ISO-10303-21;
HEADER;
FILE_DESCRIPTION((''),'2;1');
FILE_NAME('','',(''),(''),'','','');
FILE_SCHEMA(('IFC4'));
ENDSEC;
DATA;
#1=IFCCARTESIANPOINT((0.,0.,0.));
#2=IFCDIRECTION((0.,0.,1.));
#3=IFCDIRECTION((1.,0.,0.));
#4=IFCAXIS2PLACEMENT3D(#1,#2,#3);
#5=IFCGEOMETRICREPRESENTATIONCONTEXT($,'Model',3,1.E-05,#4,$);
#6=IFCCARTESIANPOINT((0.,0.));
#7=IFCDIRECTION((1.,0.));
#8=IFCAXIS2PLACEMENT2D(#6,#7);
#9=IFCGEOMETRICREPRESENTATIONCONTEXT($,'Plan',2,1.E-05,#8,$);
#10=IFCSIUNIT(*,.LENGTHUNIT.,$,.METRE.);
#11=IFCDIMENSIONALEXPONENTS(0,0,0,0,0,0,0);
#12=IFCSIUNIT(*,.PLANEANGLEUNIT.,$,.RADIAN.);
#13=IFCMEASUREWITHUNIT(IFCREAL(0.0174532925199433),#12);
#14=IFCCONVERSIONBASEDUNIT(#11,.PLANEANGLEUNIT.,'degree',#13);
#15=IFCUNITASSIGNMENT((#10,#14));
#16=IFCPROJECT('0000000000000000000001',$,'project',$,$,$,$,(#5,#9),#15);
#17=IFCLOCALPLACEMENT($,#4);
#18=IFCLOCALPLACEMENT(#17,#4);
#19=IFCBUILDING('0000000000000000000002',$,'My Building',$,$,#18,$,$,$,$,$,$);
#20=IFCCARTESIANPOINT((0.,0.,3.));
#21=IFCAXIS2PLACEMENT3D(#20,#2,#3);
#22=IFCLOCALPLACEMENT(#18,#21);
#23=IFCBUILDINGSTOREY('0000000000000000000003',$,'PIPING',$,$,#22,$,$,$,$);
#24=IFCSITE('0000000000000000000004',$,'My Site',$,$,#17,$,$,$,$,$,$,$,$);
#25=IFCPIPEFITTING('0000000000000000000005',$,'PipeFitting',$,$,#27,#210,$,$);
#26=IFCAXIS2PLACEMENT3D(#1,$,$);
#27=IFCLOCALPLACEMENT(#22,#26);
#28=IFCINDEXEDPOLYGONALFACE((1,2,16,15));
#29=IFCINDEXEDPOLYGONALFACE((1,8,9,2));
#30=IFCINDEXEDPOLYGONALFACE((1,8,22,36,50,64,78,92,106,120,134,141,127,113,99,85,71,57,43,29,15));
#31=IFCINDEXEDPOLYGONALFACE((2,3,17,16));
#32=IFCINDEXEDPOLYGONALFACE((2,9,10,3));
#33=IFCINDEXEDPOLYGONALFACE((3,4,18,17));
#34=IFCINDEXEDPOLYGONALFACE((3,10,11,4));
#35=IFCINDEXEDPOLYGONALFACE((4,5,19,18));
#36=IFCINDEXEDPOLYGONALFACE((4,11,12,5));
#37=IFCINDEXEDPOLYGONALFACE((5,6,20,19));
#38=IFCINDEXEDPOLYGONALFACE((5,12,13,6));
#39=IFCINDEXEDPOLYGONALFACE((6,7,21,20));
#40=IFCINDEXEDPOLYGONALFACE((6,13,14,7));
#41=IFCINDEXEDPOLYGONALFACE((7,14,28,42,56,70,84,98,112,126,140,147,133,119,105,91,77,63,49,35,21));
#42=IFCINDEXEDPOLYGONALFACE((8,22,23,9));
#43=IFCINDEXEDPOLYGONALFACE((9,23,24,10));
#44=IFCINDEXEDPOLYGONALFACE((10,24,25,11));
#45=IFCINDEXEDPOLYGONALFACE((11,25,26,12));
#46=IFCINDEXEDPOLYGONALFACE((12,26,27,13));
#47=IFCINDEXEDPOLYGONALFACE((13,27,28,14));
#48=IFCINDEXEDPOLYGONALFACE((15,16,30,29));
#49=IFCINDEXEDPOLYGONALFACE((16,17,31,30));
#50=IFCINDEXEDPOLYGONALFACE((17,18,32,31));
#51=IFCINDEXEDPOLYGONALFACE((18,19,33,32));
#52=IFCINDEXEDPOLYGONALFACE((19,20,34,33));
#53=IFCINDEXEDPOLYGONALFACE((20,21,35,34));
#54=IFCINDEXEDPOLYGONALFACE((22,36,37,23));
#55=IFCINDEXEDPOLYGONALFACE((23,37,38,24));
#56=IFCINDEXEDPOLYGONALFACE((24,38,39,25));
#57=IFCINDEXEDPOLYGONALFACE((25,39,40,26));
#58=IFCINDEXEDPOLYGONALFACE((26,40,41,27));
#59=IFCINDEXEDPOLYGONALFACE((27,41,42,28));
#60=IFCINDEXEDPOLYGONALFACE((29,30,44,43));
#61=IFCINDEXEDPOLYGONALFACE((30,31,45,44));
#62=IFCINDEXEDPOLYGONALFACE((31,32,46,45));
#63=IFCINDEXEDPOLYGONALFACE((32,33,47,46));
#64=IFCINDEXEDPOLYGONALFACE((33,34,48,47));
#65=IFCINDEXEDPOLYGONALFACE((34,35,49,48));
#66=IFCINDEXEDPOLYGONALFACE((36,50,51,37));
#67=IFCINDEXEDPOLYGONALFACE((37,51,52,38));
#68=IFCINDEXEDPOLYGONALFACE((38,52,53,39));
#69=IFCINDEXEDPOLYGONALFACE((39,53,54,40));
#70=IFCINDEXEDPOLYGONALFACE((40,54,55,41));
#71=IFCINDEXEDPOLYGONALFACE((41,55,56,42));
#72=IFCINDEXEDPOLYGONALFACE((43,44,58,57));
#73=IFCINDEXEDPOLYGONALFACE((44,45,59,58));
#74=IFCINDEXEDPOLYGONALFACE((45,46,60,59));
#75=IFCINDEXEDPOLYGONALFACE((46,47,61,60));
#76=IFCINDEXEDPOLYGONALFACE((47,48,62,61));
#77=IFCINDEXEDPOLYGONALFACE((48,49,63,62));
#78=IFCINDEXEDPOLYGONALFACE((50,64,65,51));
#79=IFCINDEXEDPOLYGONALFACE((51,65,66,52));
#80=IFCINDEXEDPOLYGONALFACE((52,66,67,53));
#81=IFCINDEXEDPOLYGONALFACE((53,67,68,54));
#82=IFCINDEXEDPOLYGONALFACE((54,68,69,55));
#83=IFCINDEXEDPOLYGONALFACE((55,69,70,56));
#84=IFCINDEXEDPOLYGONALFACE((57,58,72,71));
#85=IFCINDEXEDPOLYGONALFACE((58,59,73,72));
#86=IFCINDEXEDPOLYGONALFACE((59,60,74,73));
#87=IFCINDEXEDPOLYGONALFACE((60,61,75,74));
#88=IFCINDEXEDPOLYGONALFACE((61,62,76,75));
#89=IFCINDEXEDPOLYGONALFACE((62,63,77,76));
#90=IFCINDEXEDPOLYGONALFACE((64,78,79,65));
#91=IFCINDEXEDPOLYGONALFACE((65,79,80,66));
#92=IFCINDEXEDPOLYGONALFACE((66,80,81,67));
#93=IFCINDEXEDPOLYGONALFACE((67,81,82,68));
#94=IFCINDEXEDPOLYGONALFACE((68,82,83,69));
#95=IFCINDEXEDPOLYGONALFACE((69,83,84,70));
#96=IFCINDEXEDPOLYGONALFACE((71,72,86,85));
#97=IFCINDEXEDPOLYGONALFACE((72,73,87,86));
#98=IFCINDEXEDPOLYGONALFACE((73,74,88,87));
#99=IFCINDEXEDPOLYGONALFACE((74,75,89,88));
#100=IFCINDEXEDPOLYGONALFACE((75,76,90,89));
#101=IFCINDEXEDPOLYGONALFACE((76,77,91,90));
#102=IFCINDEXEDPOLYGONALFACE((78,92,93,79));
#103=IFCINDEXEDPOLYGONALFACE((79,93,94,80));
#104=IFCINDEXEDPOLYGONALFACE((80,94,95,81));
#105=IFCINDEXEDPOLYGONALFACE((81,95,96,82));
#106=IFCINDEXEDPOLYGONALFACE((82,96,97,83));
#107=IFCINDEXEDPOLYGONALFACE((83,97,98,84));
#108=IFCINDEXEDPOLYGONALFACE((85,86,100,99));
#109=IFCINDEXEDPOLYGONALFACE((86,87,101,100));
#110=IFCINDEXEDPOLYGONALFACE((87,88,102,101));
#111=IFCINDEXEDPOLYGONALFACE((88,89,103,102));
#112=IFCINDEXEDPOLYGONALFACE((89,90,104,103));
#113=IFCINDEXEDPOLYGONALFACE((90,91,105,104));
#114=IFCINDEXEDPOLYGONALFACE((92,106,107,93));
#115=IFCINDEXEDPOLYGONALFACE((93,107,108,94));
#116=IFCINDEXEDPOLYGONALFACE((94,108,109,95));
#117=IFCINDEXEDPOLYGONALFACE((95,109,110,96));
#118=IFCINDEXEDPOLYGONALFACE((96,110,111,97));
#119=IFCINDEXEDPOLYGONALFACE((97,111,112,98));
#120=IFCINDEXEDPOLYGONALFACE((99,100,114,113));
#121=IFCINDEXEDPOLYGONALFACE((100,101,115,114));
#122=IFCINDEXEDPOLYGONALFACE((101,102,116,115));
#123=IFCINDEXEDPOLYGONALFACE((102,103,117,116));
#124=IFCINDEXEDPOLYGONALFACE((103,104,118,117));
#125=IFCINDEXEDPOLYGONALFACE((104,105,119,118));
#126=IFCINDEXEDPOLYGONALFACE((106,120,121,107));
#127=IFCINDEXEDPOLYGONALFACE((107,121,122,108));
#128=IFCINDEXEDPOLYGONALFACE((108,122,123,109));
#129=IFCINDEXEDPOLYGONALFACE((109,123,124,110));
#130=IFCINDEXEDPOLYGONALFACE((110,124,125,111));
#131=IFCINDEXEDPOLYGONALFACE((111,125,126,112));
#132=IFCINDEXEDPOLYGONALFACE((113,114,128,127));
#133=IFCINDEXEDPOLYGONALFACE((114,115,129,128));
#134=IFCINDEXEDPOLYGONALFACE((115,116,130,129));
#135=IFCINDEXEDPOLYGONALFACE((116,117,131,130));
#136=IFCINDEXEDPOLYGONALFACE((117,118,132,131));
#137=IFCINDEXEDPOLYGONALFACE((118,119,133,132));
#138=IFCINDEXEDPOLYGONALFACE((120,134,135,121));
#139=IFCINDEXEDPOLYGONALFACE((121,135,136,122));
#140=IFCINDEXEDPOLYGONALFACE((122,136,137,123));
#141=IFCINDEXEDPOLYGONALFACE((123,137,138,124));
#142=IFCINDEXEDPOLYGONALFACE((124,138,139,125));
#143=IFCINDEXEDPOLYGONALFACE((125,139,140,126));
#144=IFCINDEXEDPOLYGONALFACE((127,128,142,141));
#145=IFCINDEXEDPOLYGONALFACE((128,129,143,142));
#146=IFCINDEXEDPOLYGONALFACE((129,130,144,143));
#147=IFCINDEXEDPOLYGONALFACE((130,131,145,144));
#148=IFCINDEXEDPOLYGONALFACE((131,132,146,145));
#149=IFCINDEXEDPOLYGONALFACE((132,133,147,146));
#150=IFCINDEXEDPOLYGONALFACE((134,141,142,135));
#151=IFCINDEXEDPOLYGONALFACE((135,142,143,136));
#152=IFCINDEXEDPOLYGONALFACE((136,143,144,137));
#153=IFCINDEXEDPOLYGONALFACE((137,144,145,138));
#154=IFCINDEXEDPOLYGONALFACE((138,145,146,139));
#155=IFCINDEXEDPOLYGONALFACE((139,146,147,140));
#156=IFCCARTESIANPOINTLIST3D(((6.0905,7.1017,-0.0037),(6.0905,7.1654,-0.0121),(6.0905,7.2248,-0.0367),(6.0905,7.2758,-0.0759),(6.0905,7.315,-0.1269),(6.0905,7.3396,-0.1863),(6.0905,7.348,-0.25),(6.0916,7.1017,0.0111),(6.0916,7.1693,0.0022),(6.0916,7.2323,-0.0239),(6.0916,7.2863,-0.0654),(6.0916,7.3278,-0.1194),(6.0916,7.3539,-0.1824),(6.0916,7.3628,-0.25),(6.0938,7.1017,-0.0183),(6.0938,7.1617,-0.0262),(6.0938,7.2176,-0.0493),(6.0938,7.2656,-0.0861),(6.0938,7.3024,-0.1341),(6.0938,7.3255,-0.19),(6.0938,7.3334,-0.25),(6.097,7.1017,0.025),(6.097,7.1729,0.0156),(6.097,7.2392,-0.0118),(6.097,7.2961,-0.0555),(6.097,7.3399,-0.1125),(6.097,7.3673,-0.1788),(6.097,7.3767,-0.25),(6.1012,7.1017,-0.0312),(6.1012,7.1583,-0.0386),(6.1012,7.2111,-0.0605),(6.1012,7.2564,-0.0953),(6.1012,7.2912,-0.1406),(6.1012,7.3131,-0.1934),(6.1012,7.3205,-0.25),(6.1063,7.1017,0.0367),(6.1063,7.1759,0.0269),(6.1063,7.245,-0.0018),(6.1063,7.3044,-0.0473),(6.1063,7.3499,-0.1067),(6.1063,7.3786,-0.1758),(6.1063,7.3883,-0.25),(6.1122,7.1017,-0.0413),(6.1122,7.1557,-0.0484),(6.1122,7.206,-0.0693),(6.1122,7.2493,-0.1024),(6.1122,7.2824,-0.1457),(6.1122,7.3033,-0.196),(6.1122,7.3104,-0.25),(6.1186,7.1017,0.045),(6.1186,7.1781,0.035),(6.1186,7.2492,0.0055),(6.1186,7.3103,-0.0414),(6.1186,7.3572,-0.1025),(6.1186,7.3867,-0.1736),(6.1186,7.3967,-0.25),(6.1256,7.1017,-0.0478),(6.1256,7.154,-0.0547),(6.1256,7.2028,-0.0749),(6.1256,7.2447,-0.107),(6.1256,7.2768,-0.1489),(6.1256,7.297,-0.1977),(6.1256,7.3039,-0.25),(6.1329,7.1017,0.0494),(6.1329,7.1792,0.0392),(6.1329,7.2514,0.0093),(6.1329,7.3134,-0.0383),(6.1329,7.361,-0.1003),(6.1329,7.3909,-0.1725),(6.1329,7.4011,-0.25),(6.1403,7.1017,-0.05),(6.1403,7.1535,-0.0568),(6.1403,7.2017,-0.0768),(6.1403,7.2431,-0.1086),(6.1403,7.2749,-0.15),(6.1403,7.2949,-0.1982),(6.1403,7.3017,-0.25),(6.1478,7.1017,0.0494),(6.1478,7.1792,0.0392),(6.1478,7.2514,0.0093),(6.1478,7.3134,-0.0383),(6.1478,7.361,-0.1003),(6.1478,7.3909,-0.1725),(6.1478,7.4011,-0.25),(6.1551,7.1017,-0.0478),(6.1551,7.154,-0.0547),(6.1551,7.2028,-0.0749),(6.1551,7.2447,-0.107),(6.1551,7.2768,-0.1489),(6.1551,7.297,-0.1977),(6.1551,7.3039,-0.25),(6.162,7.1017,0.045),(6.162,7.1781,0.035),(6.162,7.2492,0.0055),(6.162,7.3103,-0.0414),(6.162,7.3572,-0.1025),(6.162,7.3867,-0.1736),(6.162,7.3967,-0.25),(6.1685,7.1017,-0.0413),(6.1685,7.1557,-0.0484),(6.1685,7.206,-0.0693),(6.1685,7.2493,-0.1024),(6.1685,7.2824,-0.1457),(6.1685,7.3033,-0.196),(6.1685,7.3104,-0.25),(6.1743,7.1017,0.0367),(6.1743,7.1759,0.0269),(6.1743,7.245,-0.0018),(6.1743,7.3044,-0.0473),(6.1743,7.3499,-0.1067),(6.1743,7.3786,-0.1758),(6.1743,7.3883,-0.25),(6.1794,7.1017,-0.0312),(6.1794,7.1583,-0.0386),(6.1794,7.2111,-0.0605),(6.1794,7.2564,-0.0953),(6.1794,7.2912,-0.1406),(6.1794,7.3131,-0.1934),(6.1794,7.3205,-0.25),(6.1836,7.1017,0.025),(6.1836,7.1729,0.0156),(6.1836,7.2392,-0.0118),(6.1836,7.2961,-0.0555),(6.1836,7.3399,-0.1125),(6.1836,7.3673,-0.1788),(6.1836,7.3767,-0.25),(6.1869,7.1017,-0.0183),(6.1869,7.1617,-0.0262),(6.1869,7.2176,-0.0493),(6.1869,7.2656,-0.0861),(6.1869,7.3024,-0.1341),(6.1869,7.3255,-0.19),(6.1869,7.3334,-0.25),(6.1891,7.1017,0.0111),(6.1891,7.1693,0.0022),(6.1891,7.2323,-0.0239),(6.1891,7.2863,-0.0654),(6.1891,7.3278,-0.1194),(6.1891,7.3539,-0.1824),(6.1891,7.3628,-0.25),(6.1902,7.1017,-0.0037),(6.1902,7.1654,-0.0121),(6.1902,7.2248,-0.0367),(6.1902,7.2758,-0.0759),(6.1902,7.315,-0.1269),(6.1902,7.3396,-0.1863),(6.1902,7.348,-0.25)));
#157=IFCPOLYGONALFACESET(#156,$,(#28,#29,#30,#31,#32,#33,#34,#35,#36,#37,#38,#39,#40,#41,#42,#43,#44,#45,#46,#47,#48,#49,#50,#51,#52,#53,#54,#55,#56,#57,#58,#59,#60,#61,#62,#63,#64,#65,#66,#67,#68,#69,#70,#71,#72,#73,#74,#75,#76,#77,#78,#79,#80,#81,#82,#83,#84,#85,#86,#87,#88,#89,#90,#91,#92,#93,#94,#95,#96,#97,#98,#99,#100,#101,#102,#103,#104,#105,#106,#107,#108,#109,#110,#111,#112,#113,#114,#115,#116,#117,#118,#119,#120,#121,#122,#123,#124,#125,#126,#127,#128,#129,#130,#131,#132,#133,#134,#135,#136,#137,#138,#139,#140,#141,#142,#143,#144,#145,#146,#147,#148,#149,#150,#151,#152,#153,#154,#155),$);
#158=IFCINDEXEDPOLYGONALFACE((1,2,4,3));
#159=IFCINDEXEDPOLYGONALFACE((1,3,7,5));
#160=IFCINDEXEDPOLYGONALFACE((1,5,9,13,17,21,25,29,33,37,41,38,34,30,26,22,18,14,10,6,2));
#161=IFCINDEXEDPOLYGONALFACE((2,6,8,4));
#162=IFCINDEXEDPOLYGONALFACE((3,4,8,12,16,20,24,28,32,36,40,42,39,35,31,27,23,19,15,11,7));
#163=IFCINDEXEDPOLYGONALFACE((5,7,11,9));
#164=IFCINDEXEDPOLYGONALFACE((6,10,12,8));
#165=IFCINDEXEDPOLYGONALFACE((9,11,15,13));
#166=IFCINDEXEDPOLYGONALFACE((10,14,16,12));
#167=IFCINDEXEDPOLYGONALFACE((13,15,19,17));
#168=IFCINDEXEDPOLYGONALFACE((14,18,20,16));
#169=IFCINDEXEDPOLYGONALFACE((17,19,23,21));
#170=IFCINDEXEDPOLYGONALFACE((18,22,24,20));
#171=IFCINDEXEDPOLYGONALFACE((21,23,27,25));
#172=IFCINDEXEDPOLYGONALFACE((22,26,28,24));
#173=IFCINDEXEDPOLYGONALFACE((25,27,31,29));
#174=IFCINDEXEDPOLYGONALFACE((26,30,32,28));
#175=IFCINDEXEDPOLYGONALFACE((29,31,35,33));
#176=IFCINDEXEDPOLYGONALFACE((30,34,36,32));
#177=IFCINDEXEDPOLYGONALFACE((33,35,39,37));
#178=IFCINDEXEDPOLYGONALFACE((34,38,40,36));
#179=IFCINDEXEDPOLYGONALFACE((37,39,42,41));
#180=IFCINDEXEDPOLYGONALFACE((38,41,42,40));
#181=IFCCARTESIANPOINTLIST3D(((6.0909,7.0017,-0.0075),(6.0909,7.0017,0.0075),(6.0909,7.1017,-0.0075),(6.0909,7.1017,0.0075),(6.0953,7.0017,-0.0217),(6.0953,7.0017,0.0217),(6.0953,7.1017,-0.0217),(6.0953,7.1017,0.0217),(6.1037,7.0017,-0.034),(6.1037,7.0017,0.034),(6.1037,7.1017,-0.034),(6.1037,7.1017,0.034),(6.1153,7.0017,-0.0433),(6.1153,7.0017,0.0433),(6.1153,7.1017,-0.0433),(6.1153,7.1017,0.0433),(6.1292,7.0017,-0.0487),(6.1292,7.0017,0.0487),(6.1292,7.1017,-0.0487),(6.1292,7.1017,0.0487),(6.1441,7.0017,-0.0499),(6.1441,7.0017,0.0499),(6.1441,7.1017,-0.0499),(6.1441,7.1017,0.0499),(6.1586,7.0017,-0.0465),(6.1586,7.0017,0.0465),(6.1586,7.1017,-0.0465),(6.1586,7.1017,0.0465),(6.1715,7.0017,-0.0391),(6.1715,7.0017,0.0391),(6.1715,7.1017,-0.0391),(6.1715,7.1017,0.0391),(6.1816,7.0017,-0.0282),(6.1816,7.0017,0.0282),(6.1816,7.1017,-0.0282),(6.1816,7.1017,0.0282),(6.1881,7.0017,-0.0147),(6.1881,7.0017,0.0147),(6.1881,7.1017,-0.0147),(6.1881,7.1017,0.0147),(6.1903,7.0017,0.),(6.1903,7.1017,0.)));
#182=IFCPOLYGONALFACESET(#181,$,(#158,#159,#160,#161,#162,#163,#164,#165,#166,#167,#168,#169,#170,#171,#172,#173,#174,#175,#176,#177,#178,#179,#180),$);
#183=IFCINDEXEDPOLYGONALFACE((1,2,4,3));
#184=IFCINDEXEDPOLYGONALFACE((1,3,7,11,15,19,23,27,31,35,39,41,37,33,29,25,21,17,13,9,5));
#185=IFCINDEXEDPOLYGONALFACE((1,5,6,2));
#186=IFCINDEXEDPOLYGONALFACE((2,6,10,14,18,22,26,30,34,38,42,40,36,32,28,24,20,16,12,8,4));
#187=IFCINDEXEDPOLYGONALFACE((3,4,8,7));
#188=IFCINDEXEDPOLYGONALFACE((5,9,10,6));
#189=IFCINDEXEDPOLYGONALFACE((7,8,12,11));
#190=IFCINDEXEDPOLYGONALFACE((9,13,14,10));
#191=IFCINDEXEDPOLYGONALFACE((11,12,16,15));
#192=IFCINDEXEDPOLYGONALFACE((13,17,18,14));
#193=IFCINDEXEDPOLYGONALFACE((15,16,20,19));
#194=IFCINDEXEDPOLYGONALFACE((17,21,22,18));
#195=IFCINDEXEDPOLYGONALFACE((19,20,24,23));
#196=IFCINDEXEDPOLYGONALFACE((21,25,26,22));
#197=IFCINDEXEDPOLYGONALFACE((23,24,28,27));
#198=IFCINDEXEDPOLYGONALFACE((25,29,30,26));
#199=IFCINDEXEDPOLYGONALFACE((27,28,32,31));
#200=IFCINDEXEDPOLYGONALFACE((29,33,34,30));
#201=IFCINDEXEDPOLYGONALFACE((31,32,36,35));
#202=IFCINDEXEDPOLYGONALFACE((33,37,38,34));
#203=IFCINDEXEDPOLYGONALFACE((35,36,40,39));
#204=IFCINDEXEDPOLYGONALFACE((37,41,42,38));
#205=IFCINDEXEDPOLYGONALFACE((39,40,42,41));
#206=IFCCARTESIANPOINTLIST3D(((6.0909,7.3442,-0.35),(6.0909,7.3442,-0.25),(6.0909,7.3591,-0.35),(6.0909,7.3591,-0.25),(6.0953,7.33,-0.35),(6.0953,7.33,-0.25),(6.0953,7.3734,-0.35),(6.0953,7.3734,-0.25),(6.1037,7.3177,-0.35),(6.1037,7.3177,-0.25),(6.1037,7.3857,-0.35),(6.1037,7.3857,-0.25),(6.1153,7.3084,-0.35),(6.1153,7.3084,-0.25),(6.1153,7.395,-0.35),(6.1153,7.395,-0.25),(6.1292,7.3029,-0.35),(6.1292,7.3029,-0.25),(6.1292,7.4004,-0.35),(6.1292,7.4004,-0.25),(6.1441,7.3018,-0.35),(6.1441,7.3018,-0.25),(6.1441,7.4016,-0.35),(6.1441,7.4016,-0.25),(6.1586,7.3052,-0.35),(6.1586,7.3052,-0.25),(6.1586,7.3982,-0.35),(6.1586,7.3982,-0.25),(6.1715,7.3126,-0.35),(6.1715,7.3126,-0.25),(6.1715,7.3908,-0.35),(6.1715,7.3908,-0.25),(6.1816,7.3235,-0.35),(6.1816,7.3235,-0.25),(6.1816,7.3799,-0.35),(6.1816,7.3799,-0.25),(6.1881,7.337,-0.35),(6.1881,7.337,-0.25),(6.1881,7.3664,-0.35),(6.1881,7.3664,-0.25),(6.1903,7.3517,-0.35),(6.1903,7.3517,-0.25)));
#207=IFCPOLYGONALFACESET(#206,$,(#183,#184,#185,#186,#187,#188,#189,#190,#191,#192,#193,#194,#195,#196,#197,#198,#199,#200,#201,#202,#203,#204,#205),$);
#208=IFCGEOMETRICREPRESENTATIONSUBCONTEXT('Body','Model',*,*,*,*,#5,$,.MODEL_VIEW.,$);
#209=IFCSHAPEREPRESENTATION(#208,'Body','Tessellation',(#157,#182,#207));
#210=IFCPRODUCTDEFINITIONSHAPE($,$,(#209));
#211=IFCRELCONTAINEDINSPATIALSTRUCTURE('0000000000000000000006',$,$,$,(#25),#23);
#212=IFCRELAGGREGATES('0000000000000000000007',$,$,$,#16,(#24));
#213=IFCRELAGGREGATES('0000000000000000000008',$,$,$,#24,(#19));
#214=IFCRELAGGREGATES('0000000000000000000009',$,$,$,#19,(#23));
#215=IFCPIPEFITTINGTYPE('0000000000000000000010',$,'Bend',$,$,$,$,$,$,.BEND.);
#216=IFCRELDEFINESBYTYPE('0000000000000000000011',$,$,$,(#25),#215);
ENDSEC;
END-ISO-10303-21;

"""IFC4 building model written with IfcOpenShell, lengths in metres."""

from ifc_helpers import new_model, entity, si_unit, converted_unit, frame, origin_with_axes, origin_2d_with_axis, place, context, subcontext, project, spatial, circle, extrude, source, transform, mapped, type_object, type_shapes, element, save


model = new_model("IFC4")

# Units and contexts
model_context = context("Model", 3, precision=1e-05, world=origin_with_axes())
plan_context = context("Plan", 2, precision=1e-05, world=origin_2d_with_axis())
body_context = subcontext(model_context, "Body", "Model", "MODEL_VIEW")
ifc_project = project(units=[si_unit("LENGTHUNIT", "METRE"), converted_unit("PLANEANGLEUNIT", "degree", entity("IfcReal", 0.0174532925199433), si_unit("PLANEANGLEUNIT", "RADIAN"), dimensions=[0, 0, 0, 0, 0, 0, 0])], contexts=[model_context, plan_context])

# Site, building, storey
site_placement = place(None, origin_with_axes())
site = spatial("IfcSite", under=ifc_project, at=site_placement, Name="My Site")
building_placement = place(site_placement, origin_with_axes())
building = spatial("IfcBuilding", under=site, at=building_placement, Name="My Building")
storey_placement = place(building_placement, frame((0.0, 0.0, 3.0), z_axis=(0.0, 0.0, 1.0), x_axis=(1.0, 0.0, 0.0)))
storey = spatial("IfcBuildingStorey", under=building, at=storey_placement, Name="PIPING")

# Pipe fitting
pipe_fitting_type = type_object("IfcPipeFittingType", Name="Bend", PredefinedType="BEND")
shared_shape = source(origin_with_axes(), body_context, "Body", "SolidModel", [
    entity("IfcSweptDiskSolid", entity("IfcIndexedPolyCurve", entity("IfcCartesianPointList3D", [[0.0, 0.0, -0.1], [0.0, -0.0732, -0.2768], [0.0, -0.25, -0.35]]), [entity("IfcArcIndex", [1, 2, 3])]), 0.05),
    extrude(circle(Radius=0.05), origin_with_axes(), (0.0, 0.0, -1.0), 0.1),
    extrude(circle(Radius=0.05), frame((0.0, -0.25, -0.35), z_axis=(0.0, -1.0, 0.0), x_axis=(1.0, 0.0, 0.0)), (0.0, 0.0, 1.0), 0.1),
])
type_shapes(pipe_fitting_type, [shared_shape])
for number, where, z_axis, x_axis, name in (
    (1, (6.1403, 7.0017, 0.0), (0.0, -1.0, 0.0), (1.0, 0.0, 0.0), "PipeFitting"),
):
    element("IfcPipeFitting", number, at=place(storey_placement, frame(where, z_axis=z_axis, x_axis=x_axis)), inside=storey, type_object=pipe_fitting_type, Name=name, context=body_context, shape_type="MappedRepresentation", body=[
        mapped(shared_shape, transform((0.0, 0.0, 0.0), x_axis=(1.0, 0.0, 0.0), y_axis=(0.0, 1.0, 0.0), z_axis=(0.0, 0.0, 1.0), scale=1.0)),
    ])

save(model, "model.ifc")
